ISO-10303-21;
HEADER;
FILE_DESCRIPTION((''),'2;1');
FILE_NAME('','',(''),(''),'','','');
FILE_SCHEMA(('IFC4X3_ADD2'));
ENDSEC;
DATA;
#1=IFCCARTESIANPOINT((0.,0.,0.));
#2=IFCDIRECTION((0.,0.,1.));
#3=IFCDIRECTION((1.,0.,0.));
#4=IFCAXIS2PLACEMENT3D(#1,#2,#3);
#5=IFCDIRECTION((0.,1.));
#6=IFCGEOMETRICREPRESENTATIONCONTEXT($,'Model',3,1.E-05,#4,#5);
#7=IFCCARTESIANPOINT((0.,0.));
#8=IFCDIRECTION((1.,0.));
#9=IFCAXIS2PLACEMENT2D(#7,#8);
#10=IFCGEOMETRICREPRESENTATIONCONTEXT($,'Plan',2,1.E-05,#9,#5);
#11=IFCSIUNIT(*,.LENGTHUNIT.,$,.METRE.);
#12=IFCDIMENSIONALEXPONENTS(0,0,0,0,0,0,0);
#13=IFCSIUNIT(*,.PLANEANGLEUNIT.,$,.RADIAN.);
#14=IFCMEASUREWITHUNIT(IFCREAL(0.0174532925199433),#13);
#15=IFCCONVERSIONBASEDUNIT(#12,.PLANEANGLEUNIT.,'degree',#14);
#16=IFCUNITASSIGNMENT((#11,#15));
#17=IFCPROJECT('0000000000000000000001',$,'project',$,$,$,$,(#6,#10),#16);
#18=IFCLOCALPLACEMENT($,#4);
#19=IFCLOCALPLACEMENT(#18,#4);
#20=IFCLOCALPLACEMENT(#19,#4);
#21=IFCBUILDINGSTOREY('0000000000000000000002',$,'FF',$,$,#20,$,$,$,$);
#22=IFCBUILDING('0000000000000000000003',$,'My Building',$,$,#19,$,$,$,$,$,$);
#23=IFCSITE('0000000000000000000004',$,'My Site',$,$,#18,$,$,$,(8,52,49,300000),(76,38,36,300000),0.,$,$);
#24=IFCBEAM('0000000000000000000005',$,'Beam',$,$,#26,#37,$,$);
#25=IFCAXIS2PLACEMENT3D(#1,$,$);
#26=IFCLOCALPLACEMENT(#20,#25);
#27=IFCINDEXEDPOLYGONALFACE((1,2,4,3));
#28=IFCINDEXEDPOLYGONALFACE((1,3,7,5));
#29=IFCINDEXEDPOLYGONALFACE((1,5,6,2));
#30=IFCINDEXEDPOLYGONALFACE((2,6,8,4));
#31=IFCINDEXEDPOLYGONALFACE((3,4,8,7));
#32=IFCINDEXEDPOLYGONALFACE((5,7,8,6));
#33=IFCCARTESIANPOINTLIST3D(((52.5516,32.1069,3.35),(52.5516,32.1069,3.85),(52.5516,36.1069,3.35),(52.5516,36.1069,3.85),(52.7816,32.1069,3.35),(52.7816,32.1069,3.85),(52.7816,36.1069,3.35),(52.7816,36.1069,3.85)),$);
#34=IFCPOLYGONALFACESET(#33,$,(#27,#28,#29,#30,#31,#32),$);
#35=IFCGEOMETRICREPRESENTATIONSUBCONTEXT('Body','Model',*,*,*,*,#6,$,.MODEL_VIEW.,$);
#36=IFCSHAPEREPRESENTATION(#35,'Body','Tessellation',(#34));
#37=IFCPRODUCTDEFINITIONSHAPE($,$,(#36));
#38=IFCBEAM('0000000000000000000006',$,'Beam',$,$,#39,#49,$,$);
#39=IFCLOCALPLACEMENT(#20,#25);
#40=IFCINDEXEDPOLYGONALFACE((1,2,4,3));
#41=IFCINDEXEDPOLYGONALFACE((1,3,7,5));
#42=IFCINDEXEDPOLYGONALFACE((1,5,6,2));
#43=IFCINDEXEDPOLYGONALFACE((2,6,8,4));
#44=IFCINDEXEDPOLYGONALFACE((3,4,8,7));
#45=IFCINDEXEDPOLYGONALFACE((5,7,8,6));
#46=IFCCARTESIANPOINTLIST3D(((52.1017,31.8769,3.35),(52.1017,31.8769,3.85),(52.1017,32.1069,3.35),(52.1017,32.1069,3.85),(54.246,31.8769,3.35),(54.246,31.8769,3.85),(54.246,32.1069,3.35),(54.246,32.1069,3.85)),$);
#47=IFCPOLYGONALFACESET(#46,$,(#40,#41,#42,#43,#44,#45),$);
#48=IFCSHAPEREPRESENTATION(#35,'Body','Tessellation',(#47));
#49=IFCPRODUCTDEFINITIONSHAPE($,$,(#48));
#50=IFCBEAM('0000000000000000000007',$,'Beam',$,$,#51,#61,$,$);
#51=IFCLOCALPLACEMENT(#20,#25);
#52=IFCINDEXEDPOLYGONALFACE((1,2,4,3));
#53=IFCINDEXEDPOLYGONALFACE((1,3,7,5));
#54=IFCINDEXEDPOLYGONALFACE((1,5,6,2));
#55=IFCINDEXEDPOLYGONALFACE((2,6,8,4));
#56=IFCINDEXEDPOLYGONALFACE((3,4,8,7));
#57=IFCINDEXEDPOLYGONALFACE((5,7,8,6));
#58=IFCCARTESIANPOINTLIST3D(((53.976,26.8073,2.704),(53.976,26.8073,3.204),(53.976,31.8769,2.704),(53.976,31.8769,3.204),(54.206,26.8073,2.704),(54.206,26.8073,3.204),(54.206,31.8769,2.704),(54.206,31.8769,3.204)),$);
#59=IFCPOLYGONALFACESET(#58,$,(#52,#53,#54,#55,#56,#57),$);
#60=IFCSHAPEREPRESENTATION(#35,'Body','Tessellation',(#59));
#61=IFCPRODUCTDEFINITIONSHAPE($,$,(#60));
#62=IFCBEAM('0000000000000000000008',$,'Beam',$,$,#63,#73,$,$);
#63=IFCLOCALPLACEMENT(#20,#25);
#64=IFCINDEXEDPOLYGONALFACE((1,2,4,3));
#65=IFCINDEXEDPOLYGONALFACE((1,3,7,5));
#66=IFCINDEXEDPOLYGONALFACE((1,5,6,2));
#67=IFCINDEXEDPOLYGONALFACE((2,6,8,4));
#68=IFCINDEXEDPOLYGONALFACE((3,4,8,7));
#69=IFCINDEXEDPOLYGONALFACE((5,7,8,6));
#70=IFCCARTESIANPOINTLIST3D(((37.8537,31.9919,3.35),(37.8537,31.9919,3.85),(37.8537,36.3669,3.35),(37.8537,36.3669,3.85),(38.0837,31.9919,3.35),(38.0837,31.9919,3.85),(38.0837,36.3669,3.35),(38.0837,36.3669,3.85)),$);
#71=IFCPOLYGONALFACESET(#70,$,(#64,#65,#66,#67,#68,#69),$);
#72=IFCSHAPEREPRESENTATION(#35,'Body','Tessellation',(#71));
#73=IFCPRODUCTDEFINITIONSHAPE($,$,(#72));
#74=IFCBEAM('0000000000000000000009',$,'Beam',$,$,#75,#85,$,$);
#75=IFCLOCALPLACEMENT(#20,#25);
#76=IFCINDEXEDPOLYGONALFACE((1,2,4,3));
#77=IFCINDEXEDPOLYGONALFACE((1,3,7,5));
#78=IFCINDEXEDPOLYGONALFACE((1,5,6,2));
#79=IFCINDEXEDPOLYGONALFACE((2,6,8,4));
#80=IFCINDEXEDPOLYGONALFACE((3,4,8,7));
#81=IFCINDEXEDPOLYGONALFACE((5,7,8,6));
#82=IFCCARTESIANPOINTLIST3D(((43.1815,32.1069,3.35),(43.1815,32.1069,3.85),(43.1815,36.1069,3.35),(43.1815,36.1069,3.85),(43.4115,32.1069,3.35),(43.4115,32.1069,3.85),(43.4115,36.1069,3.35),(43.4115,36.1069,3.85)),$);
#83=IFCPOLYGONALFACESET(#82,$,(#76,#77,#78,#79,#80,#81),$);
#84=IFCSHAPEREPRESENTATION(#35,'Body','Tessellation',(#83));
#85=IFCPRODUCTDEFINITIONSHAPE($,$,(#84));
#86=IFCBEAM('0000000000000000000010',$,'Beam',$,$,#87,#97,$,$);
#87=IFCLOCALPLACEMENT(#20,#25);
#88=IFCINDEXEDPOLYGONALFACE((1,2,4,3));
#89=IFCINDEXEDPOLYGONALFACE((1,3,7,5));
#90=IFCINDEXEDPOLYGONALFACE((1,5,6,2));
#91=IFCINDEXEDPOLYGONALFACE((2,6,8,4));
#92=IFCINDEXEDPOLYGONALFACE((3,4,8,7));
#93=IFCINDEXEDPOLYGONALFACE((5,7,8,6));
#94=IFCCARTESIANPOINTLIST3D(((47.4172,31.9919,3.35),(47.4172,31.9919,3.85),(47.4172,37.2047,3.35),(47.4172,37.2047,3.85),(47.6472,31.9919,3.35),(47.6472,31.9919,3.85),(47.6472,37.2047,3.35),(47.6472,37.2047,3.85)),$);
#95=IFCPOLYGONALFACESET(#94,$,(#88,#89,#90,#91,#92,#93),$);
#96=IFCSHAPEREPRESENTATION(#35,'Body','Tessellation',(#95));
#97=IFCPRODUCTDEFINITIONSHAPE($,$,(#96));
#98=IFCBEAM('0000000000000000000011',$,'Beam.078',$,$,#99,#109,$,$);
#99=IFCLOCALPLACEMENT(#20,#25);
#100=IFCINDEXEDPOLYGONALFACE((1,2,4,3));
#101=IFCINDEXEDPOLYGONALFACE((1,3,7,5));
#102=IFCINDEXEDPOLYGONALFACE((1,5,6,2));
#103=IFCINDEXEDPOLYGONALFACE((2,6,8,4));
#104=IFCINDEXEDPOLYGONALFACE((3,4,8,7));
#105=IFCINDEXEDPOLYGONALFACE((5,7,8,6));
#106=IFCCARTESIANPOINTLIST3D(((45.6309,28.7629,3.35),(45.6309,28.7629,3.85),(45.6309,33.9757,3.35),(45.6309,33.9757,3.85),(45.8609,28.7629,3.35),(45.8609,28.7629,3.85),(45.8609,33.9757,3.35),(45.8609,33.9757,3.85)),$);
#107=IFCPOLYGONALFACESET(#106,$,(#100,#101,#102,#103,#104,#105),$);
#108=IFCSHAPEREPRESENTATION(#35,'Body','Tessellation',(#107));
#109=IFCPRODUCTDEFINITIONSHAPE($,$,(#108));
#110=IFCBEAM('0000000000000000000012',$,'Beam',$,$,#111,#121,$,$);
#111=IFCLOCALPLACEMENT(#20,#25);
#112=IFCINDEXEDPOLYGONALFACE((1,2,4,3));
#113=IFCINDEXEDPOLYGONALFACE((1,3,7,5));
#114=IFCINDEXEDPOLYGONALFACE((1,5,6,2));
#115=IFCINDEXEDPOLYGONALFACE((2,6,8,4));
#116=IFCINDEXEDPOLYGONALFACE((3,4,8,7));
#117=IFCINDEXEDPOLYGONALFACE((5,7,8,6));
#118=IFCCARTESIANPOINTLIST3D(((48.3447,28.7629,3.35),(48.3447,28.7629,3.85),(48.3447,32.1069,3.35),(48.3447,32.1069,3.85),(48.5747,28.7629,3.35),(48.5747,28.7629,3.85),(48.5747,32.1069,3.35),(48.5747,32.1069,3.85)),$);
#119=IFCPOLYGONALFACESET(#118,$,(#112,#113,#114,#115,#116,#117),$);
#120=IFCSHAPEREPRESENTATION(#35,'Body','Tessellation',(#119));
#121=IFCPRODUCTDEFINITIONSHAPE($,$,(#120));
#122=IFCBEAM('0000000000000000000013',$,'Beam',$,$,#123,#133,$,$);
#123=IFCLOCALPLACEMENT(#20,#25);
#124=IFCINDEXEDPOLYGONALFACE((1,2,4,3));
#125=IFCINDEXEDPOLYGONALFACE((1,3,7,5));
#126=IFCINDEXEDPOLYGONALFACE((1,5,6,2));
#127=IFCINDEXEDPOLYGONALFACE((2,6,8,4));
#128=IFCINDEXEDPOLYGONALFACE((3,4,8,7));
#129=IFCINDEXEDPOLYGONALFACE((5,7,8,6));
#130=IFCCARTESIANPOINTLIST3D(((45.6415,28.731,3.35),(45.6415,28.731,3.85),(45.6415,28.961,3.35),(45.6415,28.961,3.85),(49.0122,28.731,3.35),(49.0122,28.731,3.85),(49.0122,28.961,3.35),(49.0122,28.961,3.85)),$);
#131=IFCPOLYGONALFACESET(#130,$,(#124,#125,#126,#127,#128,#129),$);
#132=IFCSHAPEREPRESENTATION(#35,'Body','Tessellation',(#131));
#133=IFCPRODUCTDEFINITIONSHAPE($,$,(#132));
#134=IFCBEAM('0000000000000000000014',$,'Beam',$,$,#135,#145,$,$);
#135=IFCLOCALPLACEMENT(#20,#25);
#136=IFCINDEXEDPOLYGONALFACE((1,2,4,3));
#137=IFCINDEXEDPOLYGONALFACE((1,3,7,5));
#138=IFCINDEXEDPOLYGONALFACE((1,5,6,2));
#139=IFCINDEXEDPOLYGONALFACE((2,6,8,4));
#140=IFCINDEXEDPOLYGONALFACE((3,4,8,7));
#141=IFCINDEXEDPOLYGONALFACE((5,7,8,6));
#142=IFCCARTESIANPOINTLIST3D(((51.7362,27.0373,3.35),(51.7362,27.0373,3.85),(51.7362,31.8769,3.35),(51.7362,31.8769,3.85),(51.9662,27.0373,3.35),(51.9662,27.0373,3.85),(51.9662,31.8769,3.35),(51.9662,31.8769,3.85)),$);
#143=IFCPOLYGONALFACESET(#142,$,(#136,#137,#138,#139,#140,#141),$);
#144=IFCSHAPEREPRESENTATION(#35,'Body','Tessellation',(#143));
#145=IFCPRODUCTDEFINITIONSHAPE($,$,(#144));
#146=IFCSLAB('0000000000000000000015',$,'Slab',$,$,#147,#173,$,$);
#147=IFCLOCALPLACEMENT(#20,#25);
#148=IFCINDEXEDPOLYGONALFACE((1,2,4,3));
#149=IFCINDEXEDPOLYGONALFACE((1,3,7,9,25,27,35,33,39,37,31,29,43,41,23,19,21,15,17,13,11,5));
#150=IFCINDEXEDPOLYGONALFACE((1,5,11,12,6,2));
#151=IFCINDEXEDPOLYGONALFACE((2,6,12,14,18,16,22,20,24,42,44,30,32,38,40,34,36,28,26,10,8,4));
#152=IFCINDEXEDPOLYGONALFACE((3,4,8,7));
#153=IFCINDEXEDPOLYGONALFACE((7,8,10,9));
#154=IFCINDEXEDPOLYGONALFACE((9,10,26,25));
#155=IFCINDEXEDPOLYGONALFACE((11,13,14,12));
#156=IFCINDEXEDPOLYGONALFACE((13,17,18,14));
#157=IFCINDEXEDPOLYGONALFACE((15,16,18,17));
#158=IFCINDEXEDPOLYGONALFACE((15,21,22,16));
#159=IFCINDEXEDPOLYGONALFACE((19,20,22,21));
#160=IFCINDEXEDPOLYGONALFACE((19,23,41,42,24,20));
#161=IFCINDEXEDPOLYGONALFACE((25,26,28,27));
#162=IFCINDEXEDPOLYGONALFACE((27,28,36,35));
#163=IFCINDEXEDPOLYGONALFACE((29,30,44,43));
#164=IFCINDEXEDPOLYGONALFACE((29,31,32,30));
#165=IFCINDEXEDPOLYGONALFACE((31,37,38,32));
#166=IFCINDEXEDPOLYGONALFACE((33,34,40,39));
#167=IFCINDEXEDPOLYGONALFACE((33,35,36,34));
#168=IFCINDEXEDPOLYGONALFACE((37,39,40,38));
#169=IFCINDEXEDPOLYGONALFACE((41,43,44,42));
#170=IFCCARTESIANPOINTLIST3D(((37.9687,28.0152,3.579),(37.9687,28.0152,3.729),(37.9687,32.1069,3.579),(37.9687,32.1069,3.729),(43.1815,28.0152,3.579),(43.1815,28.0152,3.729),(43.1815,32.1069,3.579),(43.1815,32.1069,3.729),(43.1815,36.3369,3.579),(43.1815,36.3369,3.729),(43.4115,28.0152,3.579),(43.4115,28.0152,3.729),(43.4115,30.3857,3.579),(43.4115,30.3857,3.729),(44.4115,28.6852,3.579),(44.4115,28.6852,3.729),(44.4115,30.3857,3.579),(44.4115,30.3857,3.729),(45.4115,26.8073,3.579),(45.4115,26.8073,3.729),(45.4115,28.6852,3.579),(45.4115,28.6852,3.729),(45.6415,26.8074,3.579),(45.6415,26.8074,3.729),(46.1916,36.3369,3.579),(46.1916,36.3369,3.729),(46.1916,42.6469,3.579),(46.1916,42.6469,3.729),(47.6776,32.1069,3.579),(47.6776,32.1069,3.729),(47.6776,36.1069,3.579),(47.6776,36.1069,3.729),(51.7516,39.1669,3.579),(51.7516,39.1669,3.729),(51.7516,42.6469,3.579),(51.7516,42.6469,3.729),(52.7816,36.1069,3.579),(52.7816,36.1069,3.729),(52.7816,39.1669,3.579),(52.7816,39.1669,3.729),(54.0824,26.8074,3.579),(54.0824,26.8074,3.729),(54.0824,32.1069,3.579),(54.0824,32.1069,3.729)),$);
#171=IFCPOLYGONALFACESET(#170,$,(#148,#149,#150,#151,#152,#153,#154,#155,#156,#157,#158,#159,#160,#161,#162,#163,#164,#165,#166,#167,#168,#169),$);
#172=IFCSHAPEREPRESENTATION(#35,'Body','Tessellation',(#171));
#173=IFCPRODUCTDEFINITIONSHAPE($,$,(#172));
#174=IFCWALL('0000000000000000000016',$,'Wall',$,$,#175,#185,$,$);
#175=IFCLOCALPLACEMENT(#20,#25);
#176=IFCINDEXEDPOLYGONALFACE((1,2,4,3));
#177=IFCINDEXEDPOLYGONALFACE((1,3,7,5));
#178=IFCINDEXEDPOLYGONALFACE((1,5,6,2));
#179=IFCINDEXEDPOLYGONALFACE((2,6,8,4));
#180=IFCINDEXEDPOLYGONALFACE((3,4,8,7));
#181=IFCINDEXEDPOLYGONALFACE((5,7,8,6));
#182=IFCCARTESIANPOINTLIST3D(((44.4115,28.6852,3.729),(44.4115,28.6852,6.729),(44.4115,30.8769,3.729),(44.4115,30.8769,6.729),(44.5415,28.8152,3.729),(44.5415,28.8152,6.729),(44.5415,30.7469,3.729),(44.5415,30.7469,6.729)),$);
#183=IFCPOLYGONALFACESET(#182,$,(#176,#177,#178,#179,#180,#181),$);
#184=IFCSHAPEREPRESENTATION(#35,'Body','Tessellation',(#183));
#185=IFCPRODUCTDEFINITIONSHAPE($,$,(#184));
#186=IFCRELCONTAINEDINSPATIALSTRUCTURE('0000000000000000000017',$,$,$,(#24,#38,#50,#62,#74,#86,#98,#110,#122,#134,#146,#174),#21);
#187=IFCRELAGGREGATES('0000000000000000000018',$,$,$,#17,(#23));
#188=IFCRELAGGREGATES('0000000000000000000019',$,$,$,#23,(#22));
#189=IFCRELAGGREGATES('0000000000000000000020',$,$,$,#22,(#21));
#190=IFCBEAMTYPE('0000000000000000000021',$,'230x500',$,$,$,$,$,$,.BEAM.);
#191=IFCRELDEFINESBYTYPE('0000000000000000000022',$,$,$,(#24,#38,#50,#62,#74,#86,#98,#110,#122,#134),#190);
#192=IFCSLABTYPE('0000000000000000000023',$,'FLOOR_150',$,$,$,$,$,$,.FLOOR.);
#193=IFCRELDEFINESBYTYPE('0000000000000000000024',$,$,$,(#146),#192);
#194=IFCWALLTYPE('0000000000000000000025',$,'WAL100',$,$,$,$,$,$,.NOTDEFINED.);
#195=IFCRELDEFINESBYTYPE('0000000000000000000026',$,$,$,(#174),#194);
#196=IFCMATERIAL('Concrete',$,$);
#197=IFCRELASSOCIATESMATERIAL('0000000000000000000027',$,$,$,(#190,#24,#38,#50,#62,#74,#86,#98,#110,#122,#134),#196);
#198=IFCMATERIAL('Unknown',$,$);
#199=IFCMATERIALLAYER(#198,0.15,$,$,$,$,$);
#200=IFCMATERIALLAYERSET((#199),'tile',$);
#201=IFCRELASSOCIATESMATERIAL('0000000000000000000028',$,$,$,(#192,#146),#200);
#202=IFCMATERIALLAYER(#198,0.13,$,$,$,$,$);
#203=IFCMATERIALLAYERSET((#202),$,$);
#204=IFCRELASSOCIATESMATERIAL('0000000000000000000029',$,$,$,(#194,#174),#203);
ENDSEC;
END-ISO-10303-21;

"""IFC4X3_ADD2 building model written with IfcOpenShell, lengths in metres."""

from ifc_helpers import new_model, entity, si_unit, converted_unit, direction, frame, origin_with_axes, origin_2d_with_axis, place, context, subcontext, project, spatial, line, indexed_curve, rectangle, outline, extrude, material, layer, layer_set, layer_usage, material_profile, profile_set, profile_usage, type_object, element, save


model = new_model("IFC4X3_ADD2")

# Units and contexts
model_context = context("Model", 3, precision=1e-05, world=origin_with_axes(), true_north=direction((0.0, 1.0)))
plan_context = context("Plan", 2, precision=1e-05, world=origin_2d_with_axis(), true_north=direction((0.0, 1.0)))
body_context = subcontext(model_context, "Body", "Model", "MODEL_VIEW")
ifc_project = project(units=[si_unit("LENGTHUNIT", "METRE"), converted_unit("PLANEANGLEUNIT", "degree", entity("IfcReal", 0.0174532925199433), si_unit("PLANEANGLEUNIT", "RADIAN"), dimensions=[0, 0, 0, 0, 0, 0, 0])], contexts=[model_context, plan_context])

# Site, building, storey
site_placement = place(None, origin_with_axes())
site = spatial("IfcSite", under=ifc_project, at=site_placement, Name="My Site", RefLatitude=(8, 52, 49, 300000), RefLongitude=(76, 38, 36, 300000), RefElevation=0.0)
building_placement = place(site_placement, origin_with_axes())
building = spatial("IfcBuilding", under=site, at=building_placement, Name="My Building")
storey_placement = place(building_placement, origin_with_axes())
storey = spatial("IfcBuildingStorey", under=building, at=storey_placement, Name="FF")

# Beams
ifc_material_1 = material(Name="Concrete")
ifc_material_profile = material_profile(ifc_material_1, rectangle(XDim=0.23, YDim=0.5))
ifc_profile_set = profile_set([ifc_material_profile])
beam_type = type_object("IfcBeamType", Name="230x500", PredefinedType="BEAM", material=ifc_profile_set)
ifc_profile_usage_1 = profile_usage(ifc_profile_set, cardinal=5)
beam_1_placement = place(storey_placement, frame((52.6666, 32.1069, 3.6), z_axis=(0.0, 1.0, 0.0), x_axis=(-1.0, 0.0, 0.0)))
element("IfcBeam", 1, at=beam_1_placement, inside=storey, type_object=beam_type, material=ifc_profile_usage_1, Name="Beam", context=body_context, shape_type="SweptSolid", body=[
    extrude(rectangle(XDim=0.23, YDim=0.5), origin_with_axes(), (0.0, 0.0, 1.0), 4.0),
])
ifc_profile_usage_2 = profile_usage(ifc_profile_set, cardinal=5)
beam_2_placement = place(storey_placement, frame((52.1017, 31.9919, 3.6), z_axis=(1.0, 0.0, 0.0), x_axis=(0.0, 1.0, 0.0)))
element("IfcBeam", 2, at=beam_2_placement, inside=storey, type_object=beam_type, material=ifc_profile_usage_2, Name="Beam", context=body_context, shape_type="SweptSolid", body=[
    extrude(rectangle(XDim=0.23, YDim=0.5), origin_with_axes(), (0.0, 0.0, 1.0), 2.1444),
])
ifc_profile_usage_3 = profile_usage(ifc_profile_set, cardinal=5)
beam_3_placement = place(storey_placement, frame((54.091, 26.8073, 2.954), z_axis=(0.0, 1.0, 0.0), x_axis=(-1.0, 0.0, 0.0)))
element("IfcBeam", 3, at=beam_3_placement, inside=storey, type_object=beam_type, material=ifc_profile_usage_3, Name="Beam", context=body_context, shape_type="SweptSolid", body=[
    extrude(rectangle(XDim=0.23, YDim=0.5), origin_with_axes(), (0.0, 0.0, 1.0), 5.0696),
])
ifc_profile_usage_4 = profile_usage(ifc_profile_set, cardinal=5)
beam_4_placement = place(storey_placement, frame((37.9687, 31.9919, 3.6), z_axis=(0.0, 1.0, 0.0), x_axis=(-1.0, 0.0, 0.0)))
element("IfcBeam", 4, at=beam_4_placement, inside=storey, type_object=beam_type, material=ifc_profile_usage_4, Name="Beam", context=body_context, shape_type="SweptSolid", body=[
    extrude(rectangle(XDim=0.23, YDim=0.5), origin_with_axes(), (0.0, 0.0, 1.0), 4.375),
])
ifc_profile_usage_5 = profile_usage(ifc_profile_set, cardinal=5)
beam_5_placement = place(storey_placement, frame((43.2965, 32.1069, 3.6), z_axis=(0.0, 1.0, 0.0), x_axis=(-1.0, 0.0, 0.0)))
element("IfcBeam", 5, at=beam_5_placement, inside=storey, type_object=beam_type, material=ifc_profile_usage_5, Name="Beam", context=body_context, shape_type="SweptSolid", body=[
    extrude(rectangle(XDim=0.23, YDim=0.5), origin_with_axes(), (0.0, 0.0, 1.0), 4.0),
])
ifc_profile_usage_6 = profile_usage(ifc_profile_set, cardinal=5)
beam_6_placement = place(storey_placement, frame((47.5322, 31.9919, 3.6), z_axis=(0.0, 1.0, 0.0), x_axis=(-1.0, 0.0, 0.0)))
element("IfcBeam", 6, at=beam_6_placement, inside=storey, type_object=beam_type, material=ifc_profile_usage_6, Name="Beam", context=body_context, shape_type="SweptSolid", body=[
    extrude(rectangle(XDim=0.23, YDim=0.5), origin_with_axes(), (0.0, 0.0, 1.0), 5.2128),
])
ifc_profile_usage_7 = profile_usage(ifc_profile_set, cardinal=5)
beam_7_placement = place(storey_placement, frame((45.7459, 28.7629, 3.6), z_axis=(0.0, 1.0, 0.0), x_axis=(-1.0, 0.0, 0.0)))
element("IfcBeam", 7, at=beam_7_placement, inside=storey, type_object=beam_type, material=ifc_profile_usage_7, Name="Beam.078", context=body_context, shape_type="SweptSolid", body=[
    extrude(rectangle(XDim=0.23, YDim=0.5), origin_with_axes(), (0.0, 0.0, 1.0), 5.2128),
])
ifc_profile_usage_8 = profile_usage(ifc_profile_set, cardinal=5)
beam_8_placement = place(storey_placement, frame((48.4597, 28.7629, 3.6), z_axis=(0.0, 1.0, 0.0), x_axis=(-1.0, 0.0, 0.0)))
element("IfcBeam", 8, at=beam_8_placement, inside=storey, type_object=beam_type, material=ifc_profile_usage_8, Name="Beam", context=body_context, shape_type="SweptSolid", body=[
    extrude(rectangle(XDim=0.23, YDim=0.5), origin_with_axes(), (0.0, 0.0, 1.0), 3.344),
])
ifc_profile_usage_9 = profile_usage(ifc_profile_set, cardinal=5)
beam_9_placement = place(storey_placement, frame((45.6415, 28.846, 3.6), z_axis=(1.0, 0.0, 0.0), x_axis=(0.0, 1.0, 0.0)))
element("IfcBeam", 9, at=beam_9_placement, inside=storey, type_object=beam_type, material=ifc_profile_usage_9, Name="Beam", context=body_context, shape_type="SweptSolid", body=[
    extrude(rectangle(XDim=0.23, YDim=0.5), origin_with_axes(), (0.0, 0.0, 1.0), 3.3707),
])
ifc_profile_usage_10 = profile_usage(ifc_profile_set, cardinal=5)
beam_10_placement = place(storey_placement, frame((51.8512, 27.0373, 3.6), z_axis=(0.0, 1.0, 0.0), x_axis=(-1.0, 0.0, 0.0)))
element("IfcBeam", 10, at=beam_10_placement, inside=storey, type_object=beam_type, material=ifc_profile_usage_10, Name="Beam", context=body_context, shape_type="SweptSolid", body=[
    extrude(rectangle(XDim=0.23, YDim=0.5), origin_with_axes(), (0.0, 0.0, 1.0), 4.8396),
])

# Slab
ifc_material_2 = material(Name="Unknown")
ifc_layer_1 = layer(ifc_material_2, 0.15)
ifc_layer_set_1 = layer_set([ifc_layer_1], Name="tile")
ifc_layer_usage_1 = layer_usage(ifc_layer_set_1, "AXIS3", "POSITIVE", -0.15)
slab_type_1 = type_object("IfcSlabType", Name="FLOOR_150", PredefinedType="FLOOR", material=ifc_layer_set_1)
slab_1_placement = place(storey_placement, frame((37.9687, 28.0152, 3.729), z_axis=(0.0, 0.0, 1.0), x_axis=(1.0, 0.0, 0.0)))
element("IfcSlab", 11, at=slab_1_placement, inside=storey, type_object=slab_type_1, material=ifc_layer_usage_1, Name="Slab", context=body_context, shape_type="SweptSolid", body=[
    extrude(outline(indexed_curve([(14.8129, 11.1517), (14.8129, 8.0917), (9.7089, 8.0917), (9.7089, 4.0917), (16.1137, 4.0917), (16.1137, -1.2078), (7.6728, -1.2078), (7.4428, -1.2079), (7.4428, 0.67), (6.4428, 0.67), (6.4428, 2.3705), (5.4428, 2.3705), (5.4428, 0.0), (5.2128, 0.0), (0.0, 0.0), (0.0, 4.0917), (5.2127, 4.0917), (5.2127, 8.3217), (8.2229, 8.3217), (8.2229, 14.6317), (13.7829, 14.6317), (13.7829, 11.1517), (14.8129, 11.1517)])), frame((0.0, 0.0, -0.15), z_axis=(0.0, 0.0, 1.0), x_axis=(1.0, 0.0, 0.0)), (0.0, 0.0, 1.0), 0.15),
])

# Wall
ifc_layer_2 = layer(ifc_material_2, 0.13)
ifc_layer_set_2 = layer_set([ifc_layer_2])
ifc_layer_usage_2 = layer_usage(ifc_layer_set_2, "AXIS2", "POSITIVE", 0.0)
wall_type_1 = type_object("IfcWallType", Name="WAL100", PredefinedType="NOTDEFINED", material=ifc_layer_set_2)
wall_1_placement = place(storey_placement, frame((44.5415, 28.8152, 3.729), z_axis=(0.0, 0.0, 1.0), x_axis=(0.0, 1.0, 0.0)))
element("IfcWall", 12, at=wall_1_placement, inside=storey, type_object=wall_type_1, material=ifc_layer_usage_2, Name="Wall", context=body_context, shape_type="SweptSolid", body=[
    extrude(outline(indexed_curve([(0.0, 0.0), (-0.13, 0.13), (2.0617, 0.13), (1.9317, 0.0)], segments=[line(1, 2, 3, 4, 1)])), origin_with_axes(), (0.0, 0.0, 1.0), 3.0),
])

save(model, "model.ifc")
